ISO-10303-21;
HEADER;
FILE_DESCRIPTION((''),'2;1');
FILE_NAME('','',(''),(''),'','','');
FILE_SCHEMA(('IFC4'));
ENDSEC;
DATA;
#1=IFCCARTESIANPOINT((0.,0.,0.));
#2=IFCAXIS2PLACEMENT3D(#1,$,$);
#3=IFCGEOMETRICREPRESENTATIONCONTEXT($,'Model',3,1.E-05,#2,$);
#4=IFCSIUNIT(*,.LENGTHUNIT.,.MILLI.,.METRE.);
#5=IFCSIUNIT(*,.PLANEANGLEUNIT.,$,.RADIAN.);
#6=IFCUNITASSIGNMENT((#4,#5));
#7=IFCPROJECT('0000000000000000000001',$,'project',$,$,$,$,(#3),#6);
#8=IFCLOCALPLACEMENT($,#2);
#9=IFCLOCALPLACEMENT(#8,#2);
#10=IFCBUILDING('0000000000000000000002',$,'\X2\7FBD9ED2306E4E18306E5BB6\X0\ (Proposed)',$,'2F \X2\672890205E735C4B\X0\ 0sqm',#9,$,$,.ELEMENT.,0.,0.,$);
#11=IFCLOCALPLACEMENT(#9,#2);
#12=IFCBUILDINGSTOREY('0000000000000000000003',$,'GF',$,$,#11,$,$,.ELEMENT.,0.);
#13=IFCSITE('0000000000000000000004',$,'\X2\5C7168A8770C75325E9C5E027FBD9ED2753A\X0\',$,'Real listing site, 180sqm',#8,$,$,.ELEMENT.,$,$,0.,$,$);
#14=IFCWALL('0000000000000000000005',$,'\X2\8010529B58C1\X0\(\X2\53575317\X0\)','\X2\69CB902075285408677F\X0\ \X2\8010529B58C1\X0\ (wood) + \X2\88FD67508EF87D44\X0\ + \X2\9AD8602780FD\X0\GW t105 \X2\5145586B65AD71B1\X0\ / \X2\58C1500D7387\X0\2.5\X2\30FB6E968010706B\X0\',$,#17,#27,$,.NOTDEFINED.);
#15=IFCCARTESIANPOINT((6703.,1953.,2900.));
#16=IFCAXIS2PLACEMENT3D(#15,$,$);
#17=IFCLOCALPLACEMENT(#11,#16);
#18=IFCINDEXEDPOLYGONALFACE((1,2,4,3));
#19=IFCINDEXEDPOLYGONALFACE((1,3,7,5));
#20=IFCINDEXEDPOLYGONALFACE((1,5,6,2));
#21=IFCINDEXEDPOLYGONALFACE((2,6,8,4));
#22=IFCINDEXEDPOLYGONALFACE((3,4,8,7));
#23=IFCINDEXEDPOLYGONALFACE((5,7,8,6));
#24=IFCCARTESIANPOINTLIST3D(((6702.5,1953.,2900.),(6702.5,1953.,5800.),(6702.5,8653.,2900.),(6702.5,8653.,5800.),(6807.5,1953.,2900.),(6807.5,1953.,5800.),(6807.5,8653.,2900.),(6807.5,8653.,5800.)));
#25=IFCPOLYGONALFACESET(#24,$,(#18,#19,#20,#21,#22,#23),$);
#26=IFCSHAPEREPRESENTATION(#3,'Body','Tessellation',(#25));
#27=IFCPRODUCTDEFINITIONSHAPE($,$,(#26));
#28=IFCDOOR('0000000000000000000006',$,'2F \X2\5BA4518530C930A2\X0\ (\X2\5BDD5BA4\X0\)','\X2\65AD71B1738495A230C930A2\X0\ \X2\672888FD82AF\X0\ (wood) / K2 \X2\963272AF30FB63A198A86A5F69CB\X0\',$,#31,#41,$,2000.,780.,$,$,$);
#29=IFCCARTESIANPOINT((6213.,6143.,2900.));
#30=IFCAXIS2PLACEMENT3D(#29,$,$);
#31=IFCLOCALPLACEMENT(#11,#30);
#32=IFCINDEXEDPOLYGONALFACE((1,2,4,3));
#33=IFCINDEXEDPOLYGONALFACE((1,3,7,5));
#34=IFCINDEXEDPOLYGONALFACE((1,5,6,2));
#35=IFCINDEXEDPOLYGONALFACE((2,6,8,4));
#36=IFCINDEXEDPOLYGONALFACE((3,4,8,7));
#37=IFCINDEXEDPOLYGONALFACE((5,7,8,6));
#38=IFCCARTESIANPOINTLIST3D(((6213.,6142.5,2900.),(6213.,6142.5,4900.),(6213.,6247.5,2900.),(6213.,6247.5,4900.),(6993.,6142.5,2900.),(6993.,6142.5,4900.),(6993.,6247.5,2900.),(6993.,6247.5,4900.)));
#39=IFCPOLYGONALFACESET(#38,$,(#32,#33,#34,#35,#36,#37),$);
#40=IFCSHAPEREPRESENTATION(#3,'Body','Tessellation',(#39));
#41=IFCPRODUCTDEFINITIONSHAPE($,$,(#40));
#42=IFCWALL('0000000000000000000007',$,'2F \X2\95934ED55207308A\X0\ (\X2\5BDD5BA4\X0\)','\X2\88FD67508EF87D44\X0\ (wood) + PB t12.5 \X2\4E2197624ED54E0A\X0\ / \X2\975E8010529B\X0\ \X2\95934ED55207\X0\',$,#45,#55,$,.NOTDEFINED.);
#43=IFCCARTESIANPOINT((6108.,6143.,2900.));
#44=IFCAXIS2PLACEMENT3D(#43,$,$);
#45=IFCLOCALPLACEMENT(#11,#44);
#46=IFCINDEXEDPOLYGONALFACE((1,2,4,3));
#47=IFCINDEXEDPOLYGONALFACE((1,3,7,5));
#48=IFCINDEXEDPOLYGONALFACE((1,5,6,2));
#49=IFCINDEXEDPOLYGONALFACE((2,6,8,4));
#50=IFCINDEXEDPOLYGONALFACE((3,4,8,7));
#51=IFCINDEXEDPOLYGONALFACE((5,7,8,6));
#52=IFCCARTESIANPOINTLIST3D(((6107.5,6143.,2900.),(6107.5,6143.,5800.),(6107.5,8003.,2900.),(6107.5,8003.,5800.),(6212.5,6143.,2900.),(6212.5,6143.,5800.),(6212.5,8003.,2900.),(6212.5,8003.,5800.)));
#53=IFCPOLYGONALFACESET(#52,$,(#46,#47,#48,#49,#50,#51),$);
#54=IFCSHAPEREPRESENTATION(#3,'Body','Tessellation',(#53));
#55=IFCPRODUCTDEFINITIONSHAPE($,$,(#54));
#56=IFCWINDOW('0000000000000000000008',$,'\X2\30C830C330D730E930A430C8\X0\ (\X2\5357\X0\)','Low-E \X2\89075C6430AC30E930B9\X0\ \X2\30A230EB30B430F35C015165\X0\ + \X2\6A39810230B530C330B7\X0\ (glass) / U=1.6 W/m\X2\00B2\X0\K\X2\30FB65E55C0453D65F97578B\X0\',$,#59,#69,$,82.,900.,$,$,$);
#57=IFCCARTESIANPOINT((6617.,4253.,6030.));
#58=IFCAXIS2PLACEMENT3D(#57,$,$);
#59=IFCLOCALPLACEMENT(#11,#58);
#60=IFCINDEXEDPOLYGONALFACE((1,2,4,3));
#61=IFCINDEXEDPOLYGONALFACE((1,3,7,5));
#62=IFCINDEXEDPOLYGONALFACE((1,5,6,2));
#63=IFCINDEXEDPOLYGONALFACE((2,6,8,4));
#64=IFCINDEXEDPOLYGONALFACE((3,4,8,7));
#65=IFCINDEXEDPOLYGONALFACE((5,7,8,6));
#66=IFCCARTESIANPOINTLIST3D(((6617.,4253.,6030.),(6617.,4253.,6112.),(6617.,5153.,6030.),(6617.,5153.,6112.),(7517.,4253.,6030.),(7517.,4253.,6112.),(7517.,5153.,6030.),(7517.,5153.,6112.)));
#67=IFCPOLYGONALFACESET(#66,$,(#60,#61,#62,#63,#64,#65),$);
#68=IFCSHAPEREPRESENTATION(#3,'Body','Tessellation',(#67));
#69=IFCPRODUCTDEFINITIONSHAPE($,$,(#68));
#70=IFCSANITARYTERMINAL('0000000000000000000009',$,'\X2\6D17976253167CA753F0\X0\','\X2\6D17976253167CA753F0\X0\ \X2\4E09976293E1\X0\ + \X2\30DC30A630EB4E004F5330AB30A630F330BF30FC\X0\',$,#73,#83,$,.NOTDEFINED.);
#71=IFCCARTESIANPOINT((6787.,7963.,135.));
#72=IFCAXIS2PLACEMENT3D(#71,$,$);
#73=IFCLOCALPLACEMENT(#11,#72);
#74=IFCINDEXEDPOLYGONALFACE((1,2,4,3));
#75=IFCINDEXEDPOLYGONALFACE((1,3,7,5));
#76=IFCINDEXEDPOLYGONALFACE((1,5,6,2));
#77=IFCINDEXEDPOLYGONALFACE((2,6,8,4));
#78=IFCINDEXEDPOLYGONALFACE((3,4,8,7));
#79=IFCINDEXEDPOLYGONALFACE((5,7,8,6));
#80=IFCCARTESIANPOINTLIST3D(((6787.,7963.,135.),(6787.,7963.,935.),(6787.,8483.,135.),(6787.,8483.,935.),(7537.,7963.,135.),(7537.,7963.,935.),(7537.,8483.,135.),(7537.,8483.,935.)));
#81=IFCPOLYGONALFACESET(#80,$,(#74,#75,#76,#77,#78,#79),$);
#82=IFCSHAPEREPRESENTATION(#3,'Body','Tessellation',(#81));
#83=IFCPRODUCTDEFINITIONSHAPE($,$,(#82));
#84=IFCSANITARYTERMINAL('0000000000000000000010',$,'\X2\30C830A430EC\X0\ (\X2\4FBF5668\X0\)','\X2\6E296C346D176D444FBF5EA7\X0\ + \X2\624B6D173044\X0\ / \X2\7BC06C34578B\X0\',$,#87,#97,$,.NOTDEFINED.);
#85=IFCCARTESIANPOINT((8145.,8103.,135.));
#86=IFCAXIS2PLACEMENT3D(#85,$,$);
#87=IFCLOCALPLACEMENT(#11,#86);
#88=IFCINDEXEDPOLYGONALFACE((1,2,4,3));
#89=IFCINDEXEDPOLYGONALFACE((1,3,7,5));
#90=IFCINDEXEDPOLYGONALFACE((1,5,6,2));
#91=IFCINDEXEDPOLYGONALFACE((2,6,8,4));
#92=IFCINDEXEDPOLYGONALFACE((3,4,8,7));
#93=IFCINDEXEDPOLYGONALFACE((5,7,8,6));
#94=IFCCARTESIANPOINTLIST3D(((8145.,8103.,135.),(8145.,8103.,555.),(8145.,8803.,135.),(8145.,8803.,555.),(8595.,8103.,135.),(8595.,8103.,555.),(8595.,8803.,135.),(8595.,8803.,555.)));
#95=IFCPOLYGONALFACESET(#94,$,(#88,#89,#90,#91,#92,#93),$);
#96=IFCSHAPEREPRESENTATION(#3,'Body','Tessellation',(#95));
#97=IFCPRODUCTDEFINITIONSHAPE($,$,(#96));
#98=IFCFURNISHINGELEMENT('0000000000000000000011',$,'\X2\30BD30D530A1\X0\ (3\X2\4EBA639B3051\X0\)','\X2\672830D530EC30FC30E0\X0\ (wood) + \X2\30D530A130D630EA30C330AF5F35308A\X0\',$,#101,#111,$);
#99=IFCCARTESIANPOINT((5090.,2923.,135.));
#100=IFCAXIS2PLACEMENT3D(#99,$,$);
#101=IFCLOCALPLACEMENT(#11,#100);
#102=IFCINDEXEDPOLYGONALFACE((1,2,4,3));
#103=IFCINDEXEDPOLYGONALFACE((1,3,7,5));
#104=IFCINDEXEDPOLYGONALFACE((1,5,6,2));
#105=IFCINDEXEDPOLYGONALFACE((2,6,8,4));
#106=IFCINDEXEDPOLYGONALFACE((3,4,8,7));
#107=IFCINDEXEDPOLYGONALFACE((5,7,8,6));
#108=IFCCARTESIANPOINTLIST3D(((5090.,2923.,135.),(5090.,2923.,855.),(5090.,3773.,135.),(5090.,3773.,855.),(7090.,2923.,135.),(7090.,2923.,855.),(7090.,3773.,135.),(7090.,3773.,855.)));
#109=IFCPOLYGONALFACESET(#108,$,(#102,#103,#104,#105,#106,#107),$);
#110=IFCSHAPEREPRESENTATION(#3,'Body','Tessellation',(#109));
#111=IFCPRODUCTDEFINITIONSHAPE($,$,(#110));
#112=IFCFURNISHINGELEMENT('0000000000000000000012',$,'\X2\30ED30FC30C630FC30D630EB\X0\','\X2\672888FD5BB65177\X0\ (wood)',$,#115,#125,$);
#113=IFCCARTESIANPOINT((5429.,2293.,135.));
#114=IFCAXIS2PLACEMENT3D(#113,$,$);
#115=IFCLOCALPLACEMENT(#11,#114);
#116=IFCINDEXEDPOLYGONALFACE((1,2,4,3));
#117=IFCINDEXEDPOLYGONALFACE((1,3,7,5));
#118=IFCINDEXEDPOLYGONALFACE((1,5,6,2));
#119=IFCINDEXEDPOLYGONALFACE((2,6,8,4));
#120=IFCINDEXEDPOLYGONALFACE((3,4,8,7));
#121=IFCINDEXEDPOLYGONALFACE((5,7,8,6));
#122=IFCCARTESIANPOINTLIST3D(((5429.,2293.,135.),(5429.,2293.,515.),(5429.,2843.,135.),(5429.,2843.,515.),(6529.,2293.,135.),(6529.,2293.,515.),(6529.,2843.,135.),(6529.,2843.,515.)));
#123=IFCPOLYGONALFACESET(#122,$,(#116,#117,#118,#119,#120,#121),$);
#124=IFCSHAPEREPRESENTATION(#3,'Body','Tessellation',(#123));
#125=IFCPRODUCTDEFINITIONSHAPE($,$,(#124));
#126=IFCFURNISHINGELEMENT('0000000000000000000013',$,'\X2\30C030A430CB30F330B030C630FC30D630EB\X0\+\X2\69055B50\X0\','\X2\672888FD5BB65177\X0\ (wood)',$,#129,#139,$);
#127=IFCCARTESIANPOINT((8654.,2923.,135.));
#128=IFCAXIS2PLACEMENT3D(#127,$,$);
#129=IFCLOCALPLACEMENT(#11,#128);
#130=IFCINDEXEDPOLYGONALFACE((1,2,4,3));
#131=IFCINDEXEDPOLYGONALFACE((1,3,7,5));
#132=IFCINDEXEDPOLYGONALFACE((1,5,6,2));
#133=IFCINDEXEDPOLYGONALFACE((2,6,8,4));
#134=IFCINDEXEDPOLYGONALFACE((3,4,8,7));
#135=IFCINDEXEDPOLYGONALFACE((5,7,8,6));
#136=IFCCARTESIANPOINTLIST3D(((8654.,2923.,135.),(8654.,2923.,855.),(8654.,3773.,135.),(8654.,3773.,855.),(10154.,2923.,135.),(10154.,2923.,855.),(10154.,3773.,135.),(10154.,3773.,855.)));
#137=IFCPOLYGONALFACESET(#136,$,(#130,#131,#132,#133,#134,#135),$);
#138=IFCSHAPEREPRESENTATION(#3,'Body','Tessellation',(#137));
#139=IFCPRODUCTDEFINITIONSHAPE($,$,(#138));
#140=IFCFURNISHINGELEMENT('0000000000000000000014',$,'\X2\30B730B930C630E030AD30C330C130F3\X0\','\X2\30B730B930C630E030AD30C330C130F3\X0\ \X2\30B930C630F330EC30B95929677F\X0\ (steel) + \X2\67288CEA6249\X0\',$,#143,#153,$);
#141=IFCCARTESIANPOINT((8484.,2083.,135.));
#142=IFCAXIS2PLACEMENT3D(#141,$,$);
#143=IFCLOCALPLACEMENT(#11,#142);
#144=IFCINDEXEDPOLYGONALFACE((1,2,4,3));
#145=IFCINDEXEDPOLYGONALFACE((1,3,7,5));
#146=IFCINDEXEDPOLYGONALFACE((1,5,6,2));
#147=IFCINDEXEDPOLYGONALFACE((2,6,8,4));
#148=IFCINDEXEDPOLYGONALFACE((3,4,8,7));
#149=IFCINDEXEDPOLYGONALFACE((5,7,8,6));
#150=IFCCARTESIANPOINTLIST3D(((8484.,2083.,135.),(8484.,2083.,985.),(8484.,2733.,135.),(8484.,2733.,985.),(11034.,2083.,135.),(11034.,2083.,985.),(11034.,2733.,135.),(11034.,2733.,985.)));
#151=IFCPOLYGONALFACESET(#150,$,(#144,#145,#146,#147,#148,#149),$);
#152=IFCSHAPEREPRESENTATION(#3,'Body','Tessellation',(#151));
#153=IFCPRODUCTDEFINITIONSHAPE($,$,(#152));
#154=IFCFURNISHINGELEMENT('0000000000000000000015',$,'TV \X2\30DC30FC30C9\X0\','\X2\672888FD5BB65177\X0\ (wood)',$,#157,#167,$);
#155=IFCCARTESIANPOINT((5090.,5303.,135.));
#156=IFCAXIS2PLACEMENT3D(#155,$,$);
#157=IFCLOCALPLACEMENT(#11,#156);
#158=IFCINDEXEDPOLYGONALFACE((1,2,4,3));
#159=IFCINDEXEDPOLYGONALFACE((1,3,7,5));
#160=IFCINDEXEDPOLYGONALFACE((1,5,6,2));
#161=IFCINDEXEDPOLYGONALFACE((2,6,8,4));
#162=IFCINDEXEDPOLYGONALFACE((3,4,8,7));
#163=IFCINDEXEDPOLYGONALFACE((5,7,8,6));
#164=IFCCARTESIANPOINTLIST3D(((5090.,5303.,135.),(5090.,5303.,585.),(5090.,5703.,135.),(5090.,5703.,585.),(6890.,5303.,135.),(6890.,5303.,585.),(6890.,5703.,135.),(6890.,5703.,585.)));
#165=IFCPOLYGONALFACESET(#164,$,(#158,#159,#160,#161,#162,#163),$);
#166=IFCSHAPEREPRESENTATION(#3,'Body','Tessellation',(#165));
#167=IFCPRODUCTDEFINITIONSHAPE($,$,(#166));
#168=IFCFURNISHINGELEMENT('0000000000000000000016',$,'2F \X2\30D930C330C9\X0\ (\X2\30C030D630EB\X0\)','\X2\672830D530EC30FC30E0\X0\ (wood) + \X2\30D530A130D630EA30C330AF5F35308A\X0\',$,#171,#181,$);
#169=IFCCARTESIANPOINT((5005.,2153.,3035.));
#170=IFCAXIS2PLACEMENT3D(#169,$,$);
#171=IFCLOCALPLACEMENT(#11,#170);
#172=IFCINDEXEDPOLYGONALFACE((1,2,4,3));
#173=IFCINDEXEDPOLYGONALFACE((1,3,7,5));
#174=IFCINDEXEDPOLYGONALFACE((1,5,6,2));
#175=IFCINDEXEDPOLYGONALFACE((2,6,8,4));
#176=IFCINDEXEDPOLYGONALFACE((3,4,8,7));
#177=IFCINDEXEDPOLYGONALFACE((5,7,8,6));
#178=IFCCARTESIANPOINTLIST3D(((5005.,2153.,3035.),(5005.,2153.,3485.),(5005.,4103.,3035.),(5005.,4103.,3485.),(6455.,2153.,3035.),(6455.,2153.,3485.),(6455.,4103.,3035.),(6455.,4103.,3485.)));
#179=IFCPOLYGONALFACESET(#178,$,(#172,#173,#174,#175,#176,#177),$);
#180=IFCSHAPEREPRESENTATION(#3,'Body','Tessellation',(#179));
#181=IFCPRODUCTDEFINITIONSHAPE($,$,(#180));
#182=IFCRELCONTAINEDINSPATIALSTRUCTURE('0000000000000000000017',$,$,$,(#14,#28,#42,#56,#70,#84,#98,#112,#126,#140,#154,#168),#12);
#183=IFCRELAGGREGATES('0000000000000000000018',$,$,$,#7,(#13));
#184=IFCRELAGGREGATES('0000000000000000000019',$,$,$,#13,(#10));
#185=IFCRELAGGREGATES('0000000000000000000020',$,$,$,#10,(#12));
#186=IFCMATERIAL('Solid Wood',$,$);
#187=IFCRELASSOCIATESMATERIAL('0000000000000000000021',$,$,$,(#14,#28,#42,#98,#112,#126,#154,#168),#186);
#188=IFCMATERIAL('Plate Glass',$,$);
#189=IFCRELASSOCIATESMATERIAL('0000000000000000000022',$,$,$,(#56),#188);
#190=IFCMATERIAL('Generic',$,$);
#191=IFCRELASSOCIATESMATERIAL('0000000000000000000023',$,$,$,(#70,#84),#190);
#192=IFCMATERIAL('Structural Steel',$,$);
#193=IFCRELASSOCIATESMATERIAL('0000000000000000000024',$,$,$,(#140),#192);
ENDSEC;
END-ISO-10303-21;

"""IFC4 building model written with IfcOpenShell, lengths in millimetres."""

from ifc_helpers import new_model, si_unit, frame, frame_2d, origin, place, context, project, spatial, rectangle, extrude, material, element, fill, save


model = new_model("IFC4")

# Units and contexts
model_context = context("Model", 3, precision=1e-05, world=origin())
ifc_project = project(units=[si_unit("LENGTHUNIT", "METRE", prefix="MILLI"), si_unit("PLANEANGLEUNIT", "RADIAN")], contexts=[model_context])

# Site, building, storey
site_placement = place(None, origin())
site = spatial("IfcSite", under=ifc_project, at=site_placement, Name="山梨県甲府市羽黒町", ObjectType="Real listing site, 180sqm", CompositionType="ELEMENT", RefElevation=0.0)
building_placement = place(site_placement, origin())
building = spatial("IfcBuilding", under=site, at=building_placement, Name="羽黒の丘の家 (Proposed)", ObjectType="2F 木造平屋 0sqm", CompositionType="ELEMENT", ElevationOfRefHeight=0.0, ElevationOfTerrain=0.0)
storey_placement = place(building_placement, origin())
storey = spatial("IfcBuildingStorey", under=building, at=storey_placement, Name="GF", CompositionType="ELEMENT", Elevation=0.0)

# Shared definitions
ifc_material_1 = material(Name="Solid Wood")

# Wall, opening, door
wall_1_placement = place(storey_placement, frame((6703.0, 1953.0, 2900.0)))
wall_1 = element("IfcWall", 1, at=wall_1_placement, inside=storey, material=ifc_material_1, Name="耐力壁(南北)", Description="構造用合板 耐力壁 (wood) + 製材軸組 + 高性能GW t105 充填断熱 / 壁倍率2.5・準耐火", PredefinedType="NOTDEFINED", context=model_context, shape_type="SweptSolid", body=[
    extrude(rectangle(XDim=105.0, YDim=6700.0, at=frame_2d((52.0, 3350.0))), frame((6703.0, 1953.0, 2900.0)), (0.0, 0.0, 1.0), 2900.0),
])
opening_1_placement = place(storey_placement, frame((6213.0, 6143.0, 2900.0)))
opening_1 = element("IfcOpeningElement", 2, at=opening_1_placement, cuts=wall_1, PredefinedType="NOTDEFINED", context=model_context, shape_type="SweptSolid", body=[
    extrude(rectangle(XDim=780.0, YDim=105.0, at=frame_2d((390.0, 52.0))), frame((6213.0, 6143.0, 2900.0)), (0.0, 0.0, 1.0), 2000.0),
])
door_1_placement = place(storey_placement, frame((6213.0, 6143.0, 2900.0)))
door_1 = element("IfcDoor", 3, at=door_1_placement, inside=storey, material=ifc_material_1, Name="2F 室内ドア (寝室)", Description="断熱玄関ドア 木製芯 (wood) / K2 防犯・採風機構", OverallHeight=2000.0, OverallWidth=780.0, context=model_context, shape_type="SweptSolid", body=[
    extrude(rectangle(XDim=780.0, YDim=105.0, at=frame_2d((390.0, 52.0))), frame((6213.0, 6143.0, 2900.0)), (0.0, 0.0, 1.0), 2000.0),
])
fill(opening_1, door_1)

# Wall
wall_2_placement = place(storey_placement, frame((6108.0, 6143.0, 2900.0)))
element("IfcWall", 4, at=wall_2_placement, inside=storey, material=ifc_material_1, Name="2F 間仕切り (寝室)", Description="製材軸組 (wood) + PB t12.5 両面仕上 / 非耐力 間仕切", PredefinedType="NOTDEFINED", context=model_context, shape_type="SweptSolid", body=[
    extrude(rectangle(XDim=105.0, YDim=1860.0, at=frame_2d((52.0, 930.0))), frame((6108.0, 6143.0, 2900.0)), (0.0, 0.0, 1.0), 2900.0),
])

# Window
ifc_material_2 = material(Name="Plate Glass")
window_placement = place(storey_placement, frame((6617.0, 4253.0, 6030.0)))
element("IfcWindow", 5, at=window_placement, inside=storey, material=ifc_material_2, Name="トップライト (南)", Description="Low-E 複層ガラス アルゴン封入 + 樹脂サッシ (glass) / U=1.6 W/m²K・日射取得型", OverallHeight=82.0, OverallWidth=900.0, context=model_context, shape_type="SweptSolid", body=[
    extrude(rectangle(XDim=900.0, YDim=900.0, at=frame_2d((450.0, 450.0))), frame((6617.0, 4253.0, 6030.0)), (0.0, 0.0, 1.0), 82.0),
])

# Sanitary terminals
ifc_material_3 = material(Name="Generic")
sanitary_terminal_1_placement = place(storey_placement, frame((6787.0, 7963.0, 135.0)))
element("IfcSanitaryTerminal", 6, at=sanitary_terminal_1_placement, inside=storey, material=ifc_material_3, Name="洗面化粧台", Description="洗面化粧台 三面鏡 + ボウル一体カウンター", PredefinedType="NOTDEFINED", context=model_context, shape_type="SweptSolid", body=[
    extrude(rectangle(XDim=750.0, YDim=520.0, at=frame_2d((375.0, 260.0))), frame((6787.0, 7963.0, 135.0)), (0.0, 0.0, 1.0), 800.0),
])
sanitary_terminal_2_placement = place(storey_placement, frame((8145.0, 8103.0, 135.0)))
element("IfcSanitaryTerminal", 7, at=sanitary_terminal_2_placement, inside=storey, material=ifc_material_3, Name="トイレ (便器)", Description="温水洗浄便座 + 手洗い / 節水型", PredefinedType="NOTDEFINED", context=model_context, shape_type="SweptSolid", body=[
    extrude(rectangle(XDim=450.0, YDim=700.0, at=frame_2d((225.0, 350.0))), frame((8145.0, 8103.0, 135.0)), (0.0, 0.0, 1.0), 420.0),
])

# Furnishing elements
furnishing_1_placement = place(storey_placement, frame((5090.0, 2923.0, 135.0)))
element("IfcFurnishingElement", 8, at=furnishing_1_placement, inside=storey, material=ifc_material_1, Name="ソファ (3人掛け)", Description="木フレーム (wood) + ファブリック張り", context=model_context, shape_type="SweptSolid", body=[
    extrude(rectangle(XDim=2000.0, YDim=850.0, at=frame_2d((1000.0, 425.0))), frame((5090.0, 2923.0, 135.0)), (0.0, 0.0, 1.0), 720.0),
])
furnishing_2_placement = place(storey_placement, frame((5429.0, 2293.0, 135.0)))
element("IfcFurnishingElement", 9, at=furnishing_2_placement, inside=storey, material=ifc_material_1, Name="ローテーブル", Description="木製家具 (wood)", context=model_context, shape_type="SweptSolid", body=[
    extrude(rectangle(XDim=1100.0, YDim=550.0, at=frame_2d((550.0, 275.0))), frame((5429.0, 2293.0, 135.0)), (0.0, 0.0, 1.0), 380.0),
])
furnishing_3_placement = place(storey_placement, frame((8654.0, 2923.0, 135.0)))
element("IfcFurnishingElement", 10, at=furnishing_3_placement, inside=storey, material=ifc_material_1, Name="ダイニングテーブル+椅子", Description="木製家具 (wood)", context=model_context, shape_type="SweptSolid", body=[
    extrude(rectangle(XDim=1500.0, YDim=850.0, at=frame_2d((750.0, 425.0))), frame((8654.0, 2923.0, 135.0)), (0.0, 0.0, 1.0), 720.0),
])
ifc_material_4 = material(Name="Structural Steel")
furnishing_4_placement = place(storey_placement, frame((8484.0, 2083.0, 135.0)))
element("IfcFurnishingElement", 11, at=furnishing_4_placement, inside=storey, material=ifc_material_4, Name="システムキッチン", Description="システムキッチン ステンレス天板 (steel) + 木質扉", context=model_context, shape_type="SweptSolid", body=[
    extrude(rectangle(XDim=2550.0, YDim=650.0, at=frame_2d((1275.0, 325.0))), frame((8484.0, 2083.0, 135.0)), (0.0, 0.0, 1.0), 850.0),
])
furnishing_5_placement = place(storey_placement, frame((5090.0, 5303.0, 135.0)))
element("IfcFurnishingElement", 12, at=furnishing_5_placement, inside=storey, material=ifc_material_1, Name="TV ボード", Description="木製家具 (wood)", context=model_context, shape_type="SweptSolid", body=[
    extrude(rectangle(XDim=1800.0, YDim=400.0, at=frame_2d((900.0, 200.0))), frame((5090.0, 5303.0, 135.0)), (0.0, 0.0, 1.0), 450.0),
])
furnishing_6_placement = place(storey_placement, frame((5005.0, 2153.0, 3035.0)))
element("IfcFurnishingElement", 13, at=furnishing_6_placement, inside=storey, material=ifc_material_1, Name="2F ベッド (ダブル)", Description="木フレーム (wood) + ファブリック張り", context=model_context, shape_type="SweptSolid", body=[
    extrude(rectangle(XDim=1450.0, YDim=1950.0, at=frame_2d((725.0, 975.0))), frame((5005.0, 2153.0, 3035.0)), (0.0, 0.0, 1.0), 450.0),
])

save(model, "model.ifc")
